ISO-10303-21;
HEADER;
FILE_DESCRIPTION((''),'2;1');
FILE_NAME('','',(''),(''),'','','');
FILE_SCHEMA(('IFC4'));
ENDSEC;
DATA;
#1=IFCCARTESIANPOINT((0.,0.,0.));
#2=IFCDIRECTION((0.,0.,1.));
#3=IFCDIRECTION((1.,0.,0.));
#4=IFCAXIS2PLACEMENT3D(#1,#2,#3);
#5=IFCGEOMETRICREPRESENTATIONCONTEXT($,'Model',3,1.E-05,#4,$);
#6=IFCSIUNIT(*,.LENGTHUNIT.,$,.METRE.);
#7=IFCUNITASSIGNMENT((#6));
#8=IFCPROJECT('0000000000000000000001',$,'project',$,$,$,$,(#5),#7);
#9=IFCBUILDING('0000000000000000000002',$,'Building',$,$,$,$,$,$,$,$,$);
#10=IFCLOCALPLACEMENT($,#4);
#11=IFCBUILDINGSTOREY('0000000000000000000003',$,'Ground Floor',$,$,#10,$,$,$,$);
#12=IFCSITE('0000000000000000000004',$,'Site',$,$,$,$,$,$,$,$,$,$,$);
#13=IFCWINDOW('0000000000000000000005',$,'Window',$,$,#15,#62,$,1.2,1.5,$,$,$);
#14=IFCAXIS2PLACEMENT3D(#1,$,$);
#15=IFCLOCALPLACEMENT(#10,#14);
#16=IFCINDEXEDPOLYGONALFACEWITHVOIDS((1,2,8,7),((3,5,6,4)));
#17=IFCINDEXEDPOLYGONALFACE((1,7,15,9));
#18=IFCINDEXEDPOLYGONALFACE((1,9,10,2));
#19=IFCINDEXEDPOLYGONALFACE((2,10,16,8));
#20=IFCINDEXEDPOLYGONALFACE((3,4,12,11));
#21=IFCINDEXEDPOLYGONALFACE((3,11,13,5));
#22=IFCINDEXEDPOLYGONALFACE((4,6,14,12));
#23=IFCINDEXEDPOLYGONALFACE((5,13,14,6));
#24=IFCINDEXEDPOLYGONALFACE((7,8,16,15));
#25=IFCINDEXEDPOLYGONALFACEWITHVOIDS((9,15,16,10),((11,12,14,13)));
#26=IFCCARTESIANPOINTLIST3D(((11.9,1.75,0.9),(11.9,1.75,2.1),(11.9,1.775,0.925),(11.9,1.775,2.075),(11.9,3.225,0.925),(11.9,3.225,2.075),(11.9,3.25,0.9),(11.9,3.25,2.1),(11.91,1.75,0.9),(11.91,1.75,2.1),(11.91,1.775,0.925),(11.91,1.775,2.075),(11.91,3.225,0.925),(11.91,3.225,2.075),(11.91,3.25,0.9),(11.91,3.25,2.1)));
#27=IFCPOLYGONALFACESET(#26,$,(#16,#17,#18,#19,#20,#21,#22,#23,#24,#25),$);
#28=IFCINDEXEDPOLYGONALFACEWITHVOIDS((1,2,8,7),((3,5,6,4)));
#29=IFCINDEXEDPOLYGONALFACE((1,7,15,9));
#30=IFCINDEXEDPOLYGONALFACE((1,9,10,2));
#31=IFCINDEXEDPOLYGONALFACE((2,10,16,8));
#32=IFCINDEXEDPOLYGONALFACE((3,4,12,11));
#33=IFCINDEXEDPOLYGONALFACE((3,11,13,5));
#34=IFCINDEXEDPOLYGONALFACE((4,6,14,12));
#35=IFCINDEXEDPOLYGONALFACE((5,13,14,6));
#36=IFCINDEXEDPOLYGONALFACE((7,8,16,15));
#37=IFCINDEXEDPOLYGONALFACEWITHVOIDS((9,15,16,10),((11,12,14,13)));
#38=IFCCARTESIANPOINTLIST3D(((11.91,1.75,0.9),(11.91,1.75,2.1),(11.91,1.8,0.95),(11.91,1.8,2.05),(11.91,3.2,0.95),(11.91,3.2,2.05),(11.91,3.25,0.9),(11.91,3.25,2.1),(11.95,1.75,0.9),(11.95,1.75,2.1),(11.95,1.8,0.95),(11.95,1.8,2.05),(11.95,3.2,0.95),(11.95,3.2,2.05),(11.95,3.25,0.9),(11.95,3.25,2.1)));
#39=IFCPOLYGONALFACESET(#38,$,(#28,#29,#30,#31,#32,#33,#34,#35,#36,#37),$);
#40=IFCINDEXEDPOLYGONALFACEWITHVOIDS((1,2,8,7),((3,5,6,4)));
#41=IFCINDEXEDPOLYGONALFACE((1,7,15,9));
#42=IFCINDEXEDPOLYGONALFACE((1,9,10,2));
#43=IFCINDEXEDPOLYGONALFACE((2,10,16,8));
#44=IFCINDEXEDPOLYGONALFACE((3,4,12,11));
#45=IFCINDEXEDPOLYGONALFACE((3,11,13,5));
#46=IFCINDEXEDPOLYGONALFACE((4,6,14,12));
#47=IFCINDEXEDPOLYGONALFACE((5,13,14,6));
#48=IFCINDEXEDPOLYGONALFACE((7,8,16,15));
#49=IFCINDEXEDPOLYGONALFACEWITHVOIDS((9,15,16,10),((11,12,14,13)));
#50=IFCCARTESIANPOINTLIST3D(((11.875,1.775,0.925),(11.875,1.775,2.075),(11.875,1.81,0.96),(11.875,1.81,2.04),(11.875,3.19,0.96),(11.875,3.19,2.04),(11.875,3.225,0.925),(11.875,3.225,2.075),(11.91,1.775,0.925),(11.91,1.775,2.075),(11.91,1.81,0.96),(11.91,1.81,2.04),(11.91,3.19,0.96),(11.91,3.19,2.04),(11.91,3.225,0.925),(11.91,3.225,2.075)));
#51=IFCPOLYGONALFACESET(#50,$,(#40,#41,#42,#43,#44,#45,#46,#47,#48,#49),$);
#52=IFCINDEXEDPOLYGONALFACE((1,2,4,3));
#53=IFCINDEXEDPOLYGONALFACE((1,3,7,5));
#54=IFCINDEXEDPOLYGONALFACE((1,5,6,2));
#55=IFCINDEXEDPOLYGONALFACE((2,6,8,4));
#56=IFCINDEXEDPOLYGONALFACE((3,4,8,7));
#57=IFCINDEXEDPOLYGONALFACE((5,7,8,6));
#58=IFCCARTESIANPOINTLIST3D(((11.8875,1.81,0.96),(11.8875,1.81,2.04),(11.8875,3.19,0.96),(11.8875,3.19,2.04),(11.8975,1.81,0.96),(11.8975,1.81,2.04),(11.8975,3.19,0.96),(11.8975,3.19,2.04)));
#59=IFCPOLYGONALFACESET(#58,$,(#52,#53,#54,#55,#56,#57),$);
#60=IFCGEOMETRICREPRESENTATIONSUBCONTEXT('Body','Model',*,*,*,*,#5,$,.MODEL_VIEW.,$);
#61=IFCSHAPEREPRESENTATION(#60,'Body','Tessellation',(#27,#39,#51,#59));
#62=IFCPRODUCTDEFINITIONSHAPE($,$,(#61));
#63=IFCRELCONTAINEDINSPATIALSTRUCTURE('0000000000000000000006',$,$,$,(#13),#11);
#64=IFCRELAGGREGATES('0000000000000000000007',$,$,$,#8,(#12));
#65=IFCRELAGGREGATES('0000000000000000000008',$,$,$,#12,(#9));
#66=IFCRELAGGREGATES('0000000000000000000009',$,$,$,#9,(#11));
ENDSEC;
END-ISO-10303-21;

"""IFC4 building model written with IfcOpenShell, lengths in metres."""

from ifc_helpers import new_model, si_unit, frame, origin_with_axes, place, context, subcontext, project, spatial, line, indexed_curve, outline, extrude, element, save


model = new_model("IFC4")

# Units and contexts
model_context = context("Model", 3, precision=1e-05, world=origin_with_axes())
body_context = subcontext(model_context, "Body", "Model", "MODEL_VIEW")
ifc_project = project(units=[si_unit("LENGTHUNIT", "METRE")], contexts=[model_context])

# Site, building, storey
site = spatial("IfcSite", under=ifc_project, Name="Site")
building = spatial("IfcBuilding", under=site, Name="Building")
storey_placement = place(None, origin_with_axes())
storey = spatial("IfcBuildingStorey", under=building, at=storey_placement, Name="Ground Floor")

# Window
for number, where, z_axis, x_axis, name in (
    (1, (12.0, 1.75, 0.9), (0.0, 0.0, 1.0), (0.0, 1.0, 0.0), "Window"),
):
    element("IfcWindow", number, at=place(storey_placement, frame(where, z_axis=z_axis, x_axis=x_axis)), inside=storey, Name=name, OverallHeight=1.2, OverallWidth=1.5, context=body_context, shape_type="SweptSolid", body=[
        extrude(outline(indexed_curve([(0.0, 0.0), (1.5, 0.0), (1.5, 1.2), (0.0, 1.2)], segments=[line(1, 2, 3, 4, 1)]), holes=[indexed_curve([(0.025, 0.025), (1.475, 0.025), (1.475, 1.175), (0.025, 1.175)], segments=[line(1, 2, 3, 4, 1)])]), frame((0.0, 0.09, 0.0), z_axis=(0.0, -1.0, 0.0), x_axis=(1.0, 0.0, 0.0)), (0.0, 0.0, -1.0), 0.01),
        extrude(outline(indexed_curve([(0.0, 0.0), (1.5, 0.0), (1.5, 1.2), (0.0, 1.2)], segments=[line(1, 2, 3, 4, 1)]), holes=[indexed_curve([(0.05, 0.05), (1.45, 0.05), (1.45, 1.15), (0.05, 1.15)], segments=[line(1, 2, 3, 4, 1)])]), frame((0.0, 0.05, 0.0), z_axis=(0.0, -1.0, 0.0), x_axis=(1.0, 0.0, 0.0)), (0.0, 0.0, -1.0), 0.04),
        extrude(outline(indexed_curve([(0.0, 0.0), (1.45, 0.0), (1.45, 1.15), (0.0, 1.15)], segments=[line(1, 2, 3, 4, 1)]), holes=[indexed_curve([(0.035, 0.035), (1.415, 0.035), (1.415, 1.115), (0.035, 1.115)], segments=[line(1, 2, 3, 4, 1)])]), frame((0.025, 0.09, 0.025), z_axis=(0.0, -1.0, 0.0), x_axis=(1.0, 0.0, 0.0)), (0.0, 0.0, -1.0), 0.035),
        extrude(outline(indexed_curve([(0.035, 0.035), (1.415, 0.035), (1.415, 1.115), (0.035, 1.115)], segments=[line(1, 2, 3, 4, 1)])), frame((0.025, 0.1025, 0.025), z_axis=(0.0, -1.0, 0.0), x_axis=(1.0, 0.0, 0.0)), (0.0, 0.0, -1.0), 0.01),
    ])

save(model, "model.ifc")
